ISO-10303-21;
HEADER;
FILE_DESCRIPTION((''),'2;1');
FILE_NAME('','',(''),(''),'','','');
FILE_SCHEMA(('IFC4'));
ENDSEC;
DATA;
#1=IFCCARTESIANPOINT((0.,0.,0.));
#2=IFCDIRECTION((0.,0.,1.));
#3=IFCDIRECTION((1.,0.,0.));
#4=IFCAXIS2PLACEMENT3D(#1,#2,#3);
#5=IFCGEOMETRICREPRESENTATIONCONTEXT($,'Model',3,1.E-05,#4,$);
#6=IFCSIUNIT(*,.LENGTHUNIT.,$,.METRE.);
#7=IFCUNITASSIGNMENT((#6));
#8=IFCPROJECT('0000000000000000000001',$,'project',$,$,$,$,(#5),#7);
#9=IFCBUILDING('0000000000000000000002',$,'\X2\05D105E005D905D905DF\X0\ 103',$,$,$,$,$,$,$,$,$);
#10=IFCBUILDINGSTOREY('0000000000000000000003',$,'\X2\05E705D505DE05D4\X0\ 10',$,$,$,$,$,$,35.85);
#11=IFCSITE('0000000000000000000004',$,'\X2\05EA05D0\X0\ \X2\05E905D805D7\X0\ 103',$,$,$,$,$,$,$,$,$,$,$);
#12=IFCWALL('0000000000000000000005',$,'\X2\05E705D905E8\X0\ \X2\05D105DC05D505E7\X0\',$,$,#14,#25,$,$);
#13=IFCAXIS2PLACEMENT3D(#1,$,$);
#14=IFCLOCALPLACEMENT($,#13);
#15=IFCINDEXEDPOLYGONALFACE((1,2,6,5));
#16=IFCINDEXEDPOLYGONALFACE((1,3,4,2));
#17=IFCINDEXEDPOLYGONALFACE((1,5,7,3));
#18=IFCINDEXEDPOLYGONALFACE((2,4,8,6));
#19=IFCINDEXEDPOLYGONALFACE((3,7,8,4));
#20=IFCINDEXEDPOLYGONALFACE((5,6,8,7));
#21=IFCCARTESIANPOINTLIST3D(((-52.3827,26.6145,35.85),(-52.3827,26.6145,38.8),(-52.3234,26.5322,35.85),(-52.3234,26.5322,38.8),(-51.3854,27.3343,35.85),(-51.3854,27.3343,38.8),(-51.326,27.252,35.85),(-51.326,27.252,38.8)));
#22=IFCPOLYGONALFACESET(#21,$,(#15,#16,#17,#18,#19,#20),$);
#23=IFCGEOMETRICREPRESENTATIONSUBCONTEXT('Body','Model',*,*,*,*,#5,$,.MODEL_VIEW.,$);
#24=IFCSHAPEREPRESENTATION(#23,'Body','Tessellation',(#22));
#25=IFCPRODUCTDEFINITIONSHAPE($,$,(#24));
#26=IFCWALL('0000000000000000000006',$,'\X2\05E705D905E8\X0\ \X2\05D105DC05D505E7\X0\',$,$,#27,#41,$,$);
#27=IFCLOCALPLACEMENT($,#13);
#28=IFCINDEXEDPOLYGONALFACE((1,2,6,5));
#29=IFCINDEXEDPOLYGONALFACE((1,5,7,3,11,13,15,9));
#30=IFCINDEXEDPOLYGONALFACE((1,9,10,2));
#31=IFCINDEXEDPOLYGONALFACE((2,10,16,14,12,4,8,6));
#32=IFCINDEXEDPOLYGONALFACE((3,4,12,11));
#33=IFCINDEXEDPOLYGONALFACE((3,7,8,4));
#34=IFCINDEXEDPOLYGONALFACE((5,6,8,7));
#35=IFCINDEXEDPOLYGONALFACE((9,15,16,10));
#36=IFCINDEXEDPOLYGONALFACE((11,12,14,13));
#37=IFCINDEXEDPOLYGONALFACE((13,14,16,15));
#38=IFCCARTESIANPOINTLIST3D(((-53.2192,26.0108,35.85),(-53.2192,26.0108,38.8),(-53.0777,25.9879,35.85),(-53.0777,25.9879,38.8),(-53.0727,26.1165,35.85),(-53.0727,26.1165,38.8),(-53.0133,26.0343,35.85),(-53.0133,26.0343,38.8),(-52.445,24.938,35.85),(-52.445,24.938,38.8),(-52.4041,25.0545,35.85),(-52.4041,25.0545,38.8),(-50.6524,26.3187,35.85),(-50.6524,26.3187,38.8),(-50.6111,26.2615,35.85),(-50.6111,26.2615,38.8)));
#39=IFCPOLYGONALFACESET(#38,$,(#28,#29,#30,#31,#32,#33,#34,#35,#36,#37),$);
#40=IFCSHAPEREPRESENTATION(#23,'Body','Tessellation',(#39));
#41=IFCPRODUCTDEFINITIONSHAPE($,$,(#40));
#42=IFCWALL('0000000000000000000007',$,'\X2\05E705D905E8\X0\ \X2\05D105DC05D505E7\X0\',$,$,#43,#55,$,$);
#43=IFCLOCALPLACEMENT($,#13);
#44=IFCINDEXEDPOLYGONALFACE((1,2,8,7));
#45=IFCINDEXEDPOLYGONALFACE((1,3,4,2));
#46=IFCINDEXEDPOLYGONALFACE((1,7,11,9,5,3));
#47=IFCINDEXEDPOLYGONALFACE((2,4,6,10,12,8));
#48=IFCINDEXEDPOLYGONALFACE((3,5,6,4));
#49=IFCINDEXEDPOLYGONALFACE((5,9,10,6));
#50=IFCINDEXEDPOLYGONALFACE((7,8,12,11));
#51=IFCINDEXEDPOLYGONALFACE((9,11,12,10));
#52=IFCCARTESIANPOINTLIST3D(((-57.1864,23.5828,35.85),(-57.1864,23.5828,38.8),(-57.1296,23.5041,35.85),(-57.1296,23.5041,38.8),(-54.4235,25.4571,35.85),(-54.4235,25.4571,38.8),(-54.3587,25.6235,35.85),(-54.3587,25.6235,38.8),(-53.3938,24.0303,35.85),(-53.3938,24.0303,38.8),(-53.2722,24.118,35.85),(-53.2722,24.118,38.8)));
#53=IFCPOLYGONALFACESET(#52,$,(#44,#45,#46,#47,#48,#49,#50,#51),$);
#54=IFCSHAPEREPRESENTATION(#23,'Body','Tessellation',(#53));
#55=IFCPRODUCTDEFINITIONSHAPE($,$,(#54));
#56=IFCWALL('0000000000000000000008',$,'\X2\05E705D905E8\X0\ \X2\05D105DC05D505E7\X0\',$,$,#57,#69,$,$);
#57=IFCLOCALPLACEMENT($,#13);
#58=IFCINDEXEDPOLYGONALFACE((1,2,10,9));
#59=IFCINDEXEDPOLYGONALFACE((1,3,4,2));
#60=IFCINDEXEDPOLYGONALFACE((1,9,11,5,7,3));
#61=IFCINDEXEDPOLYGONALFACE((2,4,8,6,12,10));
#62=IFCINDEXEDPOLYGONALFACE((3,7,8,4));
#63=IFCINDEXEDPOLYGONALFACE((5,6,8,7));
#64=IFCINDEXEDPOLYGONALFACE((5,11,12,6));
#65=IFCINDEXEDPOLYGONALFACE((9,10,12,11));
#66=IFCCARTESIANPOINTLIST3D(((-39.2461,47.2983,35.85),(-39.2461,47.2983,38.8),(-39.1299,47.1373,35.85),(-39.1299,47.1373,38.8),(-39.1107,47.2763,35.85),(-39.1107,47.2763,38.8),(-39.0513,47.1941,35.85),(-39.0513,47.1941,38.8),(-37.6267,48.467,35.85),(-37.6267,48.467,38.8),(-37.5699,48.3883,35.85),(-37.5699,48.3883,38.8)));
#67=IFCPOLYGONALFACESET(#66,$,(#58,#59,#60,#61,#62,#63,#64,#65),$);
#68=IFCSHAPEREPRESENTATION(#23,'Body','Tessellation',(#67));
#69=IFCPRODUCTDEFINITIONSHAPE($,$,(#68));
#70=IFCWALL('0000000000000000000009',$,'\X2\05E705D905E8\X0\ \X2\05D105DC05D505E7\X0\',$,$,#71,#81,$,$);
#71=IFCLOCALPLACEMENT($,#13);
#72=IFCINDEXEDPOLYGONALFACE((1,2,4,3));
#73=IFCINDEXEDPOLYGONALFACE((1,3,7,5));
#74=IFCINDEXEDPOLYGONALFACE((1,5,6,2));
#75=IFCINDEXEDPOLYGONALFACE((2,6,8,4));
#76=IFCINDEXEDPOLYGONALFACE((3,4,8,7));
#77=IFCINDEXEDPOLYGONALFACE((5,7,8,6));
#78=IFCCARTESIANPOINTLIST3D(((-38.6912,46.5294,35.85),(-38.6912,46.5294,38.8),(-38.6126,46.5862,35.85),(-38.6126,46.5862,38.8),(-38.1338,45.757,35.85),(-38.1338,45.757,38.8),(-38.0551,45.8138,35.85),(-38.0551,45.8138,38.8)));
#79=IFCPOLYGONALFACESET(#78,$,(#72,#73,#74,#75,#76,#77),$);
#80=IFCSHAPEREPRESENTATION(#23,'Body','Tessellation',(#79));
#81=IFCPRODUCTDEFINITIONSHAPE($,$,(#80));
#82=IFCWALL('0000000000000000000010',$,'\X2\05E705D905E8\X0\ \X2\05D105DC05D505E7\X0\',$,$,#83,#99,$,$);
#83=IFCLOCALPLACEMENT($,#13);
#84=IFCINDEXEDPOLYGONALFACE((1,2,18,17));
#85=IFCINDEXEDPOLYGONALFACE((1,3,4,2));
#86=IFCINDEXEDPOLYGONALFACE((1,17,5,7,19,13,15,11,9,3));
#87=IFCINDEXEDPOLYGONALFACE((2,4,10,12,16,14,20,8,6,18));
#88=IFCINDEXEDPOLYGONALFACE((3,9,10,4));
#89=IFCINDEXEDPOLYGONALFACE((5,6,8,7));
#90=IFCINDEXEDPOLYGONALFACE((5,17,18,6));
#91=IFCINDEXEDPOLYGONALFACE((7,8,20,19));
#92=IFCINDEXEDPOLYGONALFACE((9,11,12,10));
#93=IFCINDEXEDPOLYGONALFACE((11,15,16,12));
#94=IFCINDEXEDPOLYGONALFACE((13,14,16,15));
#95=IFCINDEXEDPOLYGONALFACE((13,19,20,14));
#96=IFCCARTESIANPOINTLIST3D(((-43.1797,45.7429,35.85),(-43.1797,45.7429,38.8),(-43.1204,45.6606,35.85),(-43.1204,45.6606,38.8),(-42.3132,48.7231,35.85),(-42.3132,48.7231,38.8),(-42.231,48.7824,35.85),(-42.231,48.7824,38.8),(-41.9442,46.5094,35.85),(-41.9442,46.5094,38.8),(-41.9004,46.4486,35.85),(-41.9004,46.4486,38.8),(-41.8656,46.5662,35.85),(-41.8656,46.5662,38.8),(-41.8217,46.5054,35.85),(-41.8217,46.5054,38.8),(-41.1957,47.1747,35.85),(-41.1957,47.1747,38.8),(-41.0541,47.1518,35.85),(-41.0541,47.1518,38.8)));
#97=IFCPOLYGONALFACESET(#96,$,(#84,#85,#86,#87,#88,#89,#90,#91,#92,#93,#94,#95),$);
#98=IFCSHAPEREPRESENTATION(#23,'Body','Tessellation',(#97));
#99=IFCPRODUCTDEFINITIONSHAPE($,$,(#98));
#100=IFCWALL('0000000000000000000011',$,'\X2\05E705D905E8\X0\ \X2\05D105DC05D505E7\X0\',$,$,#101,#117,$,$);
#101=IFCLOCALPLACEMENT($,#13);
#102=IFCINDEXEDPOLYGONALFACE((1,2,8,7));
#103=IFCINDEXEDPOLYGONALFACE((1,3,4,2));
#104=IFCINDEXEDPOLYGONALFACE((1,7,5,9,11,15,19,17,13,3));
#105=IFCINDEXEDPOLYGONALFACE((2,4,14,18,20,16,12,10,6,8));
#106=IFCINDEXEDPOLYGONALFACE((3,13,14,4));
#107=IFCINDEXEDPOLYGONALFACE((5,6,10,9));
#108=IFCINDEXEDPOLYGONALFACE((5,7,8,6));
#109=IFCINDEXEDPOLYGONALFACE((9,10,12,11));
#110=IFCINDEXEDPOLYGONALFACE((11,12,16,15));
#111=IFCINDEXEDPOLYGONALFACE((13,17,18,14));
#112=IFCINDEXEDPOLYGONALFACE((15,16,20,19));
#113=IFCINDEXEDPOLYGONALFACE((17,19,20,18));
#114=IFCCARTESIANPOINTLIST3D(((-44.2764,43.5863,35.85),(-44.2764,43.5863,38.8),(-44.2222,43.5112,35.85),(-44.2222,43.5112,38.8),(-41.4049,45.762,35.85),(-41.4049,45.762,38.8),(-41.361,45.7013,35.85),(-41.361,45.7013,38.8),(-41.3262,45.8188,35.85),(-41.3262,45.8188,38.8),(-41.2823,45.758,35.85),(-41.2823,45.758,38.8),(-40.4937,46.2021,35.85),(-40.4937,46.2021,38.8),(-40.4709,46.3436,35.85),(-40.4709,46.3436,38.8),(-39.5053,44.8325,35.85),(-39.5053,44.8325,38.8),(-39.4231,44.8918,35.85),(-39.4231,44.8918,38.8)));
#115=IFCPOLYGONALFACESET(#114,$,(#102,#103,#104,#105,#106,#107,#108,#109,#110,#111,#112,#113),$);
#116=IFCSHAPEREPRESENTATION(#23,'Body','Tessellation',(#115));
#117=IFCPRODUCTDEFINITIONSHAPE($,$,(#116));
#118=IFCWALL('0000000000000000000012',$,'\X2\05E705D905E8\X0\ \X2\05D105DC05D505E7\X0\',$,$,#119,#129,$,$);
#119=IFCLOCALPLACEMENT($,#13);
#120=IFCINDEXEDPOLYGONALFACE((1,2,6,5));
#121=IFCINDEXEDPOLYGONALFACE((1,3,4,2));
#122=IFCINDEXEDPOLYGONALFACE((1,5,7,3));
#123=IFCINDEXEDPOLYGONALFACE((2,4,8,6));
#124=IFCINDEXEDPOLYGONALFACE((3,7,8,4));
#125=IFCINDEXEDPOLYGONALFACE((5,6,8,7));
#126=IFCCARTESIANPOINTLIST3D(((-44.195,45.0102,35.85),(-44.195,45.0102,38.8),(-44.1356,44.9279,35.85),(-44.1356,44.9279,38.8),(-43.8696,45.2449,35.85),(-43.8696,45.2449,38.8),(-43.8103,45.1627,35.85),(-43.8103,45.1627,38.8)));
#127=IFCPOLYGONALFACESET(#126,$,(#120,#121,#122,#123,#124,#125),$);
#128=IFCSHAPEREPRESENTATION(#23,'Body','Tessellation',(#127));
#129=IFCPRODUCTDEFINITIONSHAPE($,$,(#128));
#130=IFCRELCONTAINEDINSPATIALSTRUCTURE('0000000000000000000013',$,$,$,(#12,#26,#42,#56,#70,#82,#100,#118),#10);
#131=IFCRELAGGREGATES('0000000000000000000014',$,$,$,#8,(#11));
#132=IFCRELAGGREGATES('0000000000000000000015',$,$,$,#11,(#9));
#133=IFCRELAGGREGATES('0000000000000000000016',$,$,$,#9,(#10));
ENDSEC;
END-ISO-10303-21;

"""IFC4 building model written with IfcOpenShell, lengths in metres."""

from ifc_helpers import new_model, si_unit, frame, origin_with_axes, context, subcontext, project, spatial, polyline, outline, extrude, element, save


model = new_model("IFC4")

# Units and contexts
model_context = context("Model", 3, precision=1e-05, world=origin_with_axes())
body_context = subcontext(model_context, "Body", "Model", "MODEL_VIEW")
ifc_project = project(units=[si_unit("LENGTHUNIT", "METRE")], contexts=[model_context])

# Site, building, storey
site = spatial("IfcSite", under=ifc_project, Name="תא שטח 103")
building = spatial("IfcBuilding", under=site, Name="בניין 103")
storey = spatial("IfcBuildingStorey", under=building, Name="קומה 10", Elevation=35.85)

# Walls
element("IfcWall", 1, inside=storey, Name="קיר בלוק", context=body_context, shape_type="SweptSolid", body=[
    extrude(outline(polyline([(-52.3827, 26.6145), (-51.3854, 27.3343), (-51.326, 27.252), (-52.3234, 26.5322), (-52.3827, 26.6145)])), frame((0.0, 0.0, 35.85)), (0.0, 0.0, 1.0), 2.95),
])
element("IfcWall", 2, inside=storey, Name="קיר בלוק", context=body_context, shape_type="SweptSolid", body=[
    extrude(outline(polyline([(-53.2192, 26.0108), (-53.0727, 26.1165), (-53.0133, 26.0343), (-53.0777, 25.9879), (-52.4041, 25.0545), (-50.6524, 26.3187), (-50.6111, 26.2615), (-52.445, 24.938), (-53.2192, 26.0108)])), frame((0.0, 0.0, 35.85)), (0.0, 0.0, 1.0), 2.95),
])
element("IfcWall", 3, inside=storey, Name="קיר בלוק", context=body_context, shape_type="SweptSolid", body=[
    extrude(outline(polyline([(-53.3938, 24.0303), (-54.4235, 25.4571), (-57.1296, 23.5041), (-57.1864, 23.5828), (-54.3587, 25.6235), (-53.2722, 24.118), (-53.3938, 24.0303)])), frame((0.0, 0.0, 35.85)), (0.0, 0.0, 1.0), 2.95),
])
element("IfcWall", 4, inside=storey, Name="קיר בלוק", context=body_context, shape_type="SweptSolid", body=[
    extrude(outline(polyline([(-39.1299, 47.1373), (-39.2461, 47.2983), (-37.6267, 48.467), (-37.5699, 48.3883), (-39.1107, 47.2763), (-39.0513, 47.1941), (-39.1299, 47.1373)])), frame((0.0, 0.0, 35.85)), (0.0, 0.0, 1.0), 2.95),
])
element("IfcWall", 5, inside=storey, Name="קיר בלוק", context=body_context, shape_type="SweptSolid", body=[
    extrude(outline(polyline([(-38.6126, 46.5862), (-38.0551, 45.8138), (-38.1338, 45.757), (-38.6912, 46.5294), (-38.6126, 46.5862)])), frame((0.0, 0.0, 35.85)), (0.0, 0.0, 1.0), 2.95),
])
element("IfcWall", 6, inside=storey, Name="קיר בלוק", context=body_context, shape_type="SweptSolid", body=[
    extrude(outline(polyline([(-41.9004, 46.4486), (-41.9442, 46.5094), (-43.1204, 45.6606), (-43.1797, 45.7429), (-41.1957, 47.1747), (-42.3132, 48.7231), (-42.231, 48.7824), (-41.0541, 47.1518), (-41.8656, 46.5662), (-41.8217, 46.5054), (-41.9004, 46.4486)])), frame((0.0, 0.0, 35.85)), (0.0, 0.0, 1.0), 2.95),
])
element("IfcWall", 7, inside=storey, Name="קיר בלוק", context=body_context, shape_type="SweptSolid", body=[
    extrude(outline(polyline([(-44.2764, 43.5863), (-41.361, 45.7013), (-41.4049, 45.762), (-41.3262, 45.8188), (-41.2823, 45.758), (-40.4709, 46.3436), (-39.4231, 44.8918), (-39.5053, 44.8325), (-40.4937, 46.2021), (-44.2222, 43.5112), (-44.2764, 43.5863)])), frame((0.0, 0.0, 35.85)), (0.0, 0.0, 1.0), 2.95),
])
element("IfcWall", 8, inside=storey, Name="קיר בלוק", context=body_context, shape_type="SweptSolid", body=[
    extrude(outline(polyline([(-43.8103, 45.1627), (-44.1356, 44.9279), (-44.195, 45.0102), (-43.8696, 45.2449), (-43.8103, 45.1627)])), frame((0.0, 0.0, 35.85)), (0.0, 0.0, 1.0), 2.95),
])

save(model, "model.ifc")
